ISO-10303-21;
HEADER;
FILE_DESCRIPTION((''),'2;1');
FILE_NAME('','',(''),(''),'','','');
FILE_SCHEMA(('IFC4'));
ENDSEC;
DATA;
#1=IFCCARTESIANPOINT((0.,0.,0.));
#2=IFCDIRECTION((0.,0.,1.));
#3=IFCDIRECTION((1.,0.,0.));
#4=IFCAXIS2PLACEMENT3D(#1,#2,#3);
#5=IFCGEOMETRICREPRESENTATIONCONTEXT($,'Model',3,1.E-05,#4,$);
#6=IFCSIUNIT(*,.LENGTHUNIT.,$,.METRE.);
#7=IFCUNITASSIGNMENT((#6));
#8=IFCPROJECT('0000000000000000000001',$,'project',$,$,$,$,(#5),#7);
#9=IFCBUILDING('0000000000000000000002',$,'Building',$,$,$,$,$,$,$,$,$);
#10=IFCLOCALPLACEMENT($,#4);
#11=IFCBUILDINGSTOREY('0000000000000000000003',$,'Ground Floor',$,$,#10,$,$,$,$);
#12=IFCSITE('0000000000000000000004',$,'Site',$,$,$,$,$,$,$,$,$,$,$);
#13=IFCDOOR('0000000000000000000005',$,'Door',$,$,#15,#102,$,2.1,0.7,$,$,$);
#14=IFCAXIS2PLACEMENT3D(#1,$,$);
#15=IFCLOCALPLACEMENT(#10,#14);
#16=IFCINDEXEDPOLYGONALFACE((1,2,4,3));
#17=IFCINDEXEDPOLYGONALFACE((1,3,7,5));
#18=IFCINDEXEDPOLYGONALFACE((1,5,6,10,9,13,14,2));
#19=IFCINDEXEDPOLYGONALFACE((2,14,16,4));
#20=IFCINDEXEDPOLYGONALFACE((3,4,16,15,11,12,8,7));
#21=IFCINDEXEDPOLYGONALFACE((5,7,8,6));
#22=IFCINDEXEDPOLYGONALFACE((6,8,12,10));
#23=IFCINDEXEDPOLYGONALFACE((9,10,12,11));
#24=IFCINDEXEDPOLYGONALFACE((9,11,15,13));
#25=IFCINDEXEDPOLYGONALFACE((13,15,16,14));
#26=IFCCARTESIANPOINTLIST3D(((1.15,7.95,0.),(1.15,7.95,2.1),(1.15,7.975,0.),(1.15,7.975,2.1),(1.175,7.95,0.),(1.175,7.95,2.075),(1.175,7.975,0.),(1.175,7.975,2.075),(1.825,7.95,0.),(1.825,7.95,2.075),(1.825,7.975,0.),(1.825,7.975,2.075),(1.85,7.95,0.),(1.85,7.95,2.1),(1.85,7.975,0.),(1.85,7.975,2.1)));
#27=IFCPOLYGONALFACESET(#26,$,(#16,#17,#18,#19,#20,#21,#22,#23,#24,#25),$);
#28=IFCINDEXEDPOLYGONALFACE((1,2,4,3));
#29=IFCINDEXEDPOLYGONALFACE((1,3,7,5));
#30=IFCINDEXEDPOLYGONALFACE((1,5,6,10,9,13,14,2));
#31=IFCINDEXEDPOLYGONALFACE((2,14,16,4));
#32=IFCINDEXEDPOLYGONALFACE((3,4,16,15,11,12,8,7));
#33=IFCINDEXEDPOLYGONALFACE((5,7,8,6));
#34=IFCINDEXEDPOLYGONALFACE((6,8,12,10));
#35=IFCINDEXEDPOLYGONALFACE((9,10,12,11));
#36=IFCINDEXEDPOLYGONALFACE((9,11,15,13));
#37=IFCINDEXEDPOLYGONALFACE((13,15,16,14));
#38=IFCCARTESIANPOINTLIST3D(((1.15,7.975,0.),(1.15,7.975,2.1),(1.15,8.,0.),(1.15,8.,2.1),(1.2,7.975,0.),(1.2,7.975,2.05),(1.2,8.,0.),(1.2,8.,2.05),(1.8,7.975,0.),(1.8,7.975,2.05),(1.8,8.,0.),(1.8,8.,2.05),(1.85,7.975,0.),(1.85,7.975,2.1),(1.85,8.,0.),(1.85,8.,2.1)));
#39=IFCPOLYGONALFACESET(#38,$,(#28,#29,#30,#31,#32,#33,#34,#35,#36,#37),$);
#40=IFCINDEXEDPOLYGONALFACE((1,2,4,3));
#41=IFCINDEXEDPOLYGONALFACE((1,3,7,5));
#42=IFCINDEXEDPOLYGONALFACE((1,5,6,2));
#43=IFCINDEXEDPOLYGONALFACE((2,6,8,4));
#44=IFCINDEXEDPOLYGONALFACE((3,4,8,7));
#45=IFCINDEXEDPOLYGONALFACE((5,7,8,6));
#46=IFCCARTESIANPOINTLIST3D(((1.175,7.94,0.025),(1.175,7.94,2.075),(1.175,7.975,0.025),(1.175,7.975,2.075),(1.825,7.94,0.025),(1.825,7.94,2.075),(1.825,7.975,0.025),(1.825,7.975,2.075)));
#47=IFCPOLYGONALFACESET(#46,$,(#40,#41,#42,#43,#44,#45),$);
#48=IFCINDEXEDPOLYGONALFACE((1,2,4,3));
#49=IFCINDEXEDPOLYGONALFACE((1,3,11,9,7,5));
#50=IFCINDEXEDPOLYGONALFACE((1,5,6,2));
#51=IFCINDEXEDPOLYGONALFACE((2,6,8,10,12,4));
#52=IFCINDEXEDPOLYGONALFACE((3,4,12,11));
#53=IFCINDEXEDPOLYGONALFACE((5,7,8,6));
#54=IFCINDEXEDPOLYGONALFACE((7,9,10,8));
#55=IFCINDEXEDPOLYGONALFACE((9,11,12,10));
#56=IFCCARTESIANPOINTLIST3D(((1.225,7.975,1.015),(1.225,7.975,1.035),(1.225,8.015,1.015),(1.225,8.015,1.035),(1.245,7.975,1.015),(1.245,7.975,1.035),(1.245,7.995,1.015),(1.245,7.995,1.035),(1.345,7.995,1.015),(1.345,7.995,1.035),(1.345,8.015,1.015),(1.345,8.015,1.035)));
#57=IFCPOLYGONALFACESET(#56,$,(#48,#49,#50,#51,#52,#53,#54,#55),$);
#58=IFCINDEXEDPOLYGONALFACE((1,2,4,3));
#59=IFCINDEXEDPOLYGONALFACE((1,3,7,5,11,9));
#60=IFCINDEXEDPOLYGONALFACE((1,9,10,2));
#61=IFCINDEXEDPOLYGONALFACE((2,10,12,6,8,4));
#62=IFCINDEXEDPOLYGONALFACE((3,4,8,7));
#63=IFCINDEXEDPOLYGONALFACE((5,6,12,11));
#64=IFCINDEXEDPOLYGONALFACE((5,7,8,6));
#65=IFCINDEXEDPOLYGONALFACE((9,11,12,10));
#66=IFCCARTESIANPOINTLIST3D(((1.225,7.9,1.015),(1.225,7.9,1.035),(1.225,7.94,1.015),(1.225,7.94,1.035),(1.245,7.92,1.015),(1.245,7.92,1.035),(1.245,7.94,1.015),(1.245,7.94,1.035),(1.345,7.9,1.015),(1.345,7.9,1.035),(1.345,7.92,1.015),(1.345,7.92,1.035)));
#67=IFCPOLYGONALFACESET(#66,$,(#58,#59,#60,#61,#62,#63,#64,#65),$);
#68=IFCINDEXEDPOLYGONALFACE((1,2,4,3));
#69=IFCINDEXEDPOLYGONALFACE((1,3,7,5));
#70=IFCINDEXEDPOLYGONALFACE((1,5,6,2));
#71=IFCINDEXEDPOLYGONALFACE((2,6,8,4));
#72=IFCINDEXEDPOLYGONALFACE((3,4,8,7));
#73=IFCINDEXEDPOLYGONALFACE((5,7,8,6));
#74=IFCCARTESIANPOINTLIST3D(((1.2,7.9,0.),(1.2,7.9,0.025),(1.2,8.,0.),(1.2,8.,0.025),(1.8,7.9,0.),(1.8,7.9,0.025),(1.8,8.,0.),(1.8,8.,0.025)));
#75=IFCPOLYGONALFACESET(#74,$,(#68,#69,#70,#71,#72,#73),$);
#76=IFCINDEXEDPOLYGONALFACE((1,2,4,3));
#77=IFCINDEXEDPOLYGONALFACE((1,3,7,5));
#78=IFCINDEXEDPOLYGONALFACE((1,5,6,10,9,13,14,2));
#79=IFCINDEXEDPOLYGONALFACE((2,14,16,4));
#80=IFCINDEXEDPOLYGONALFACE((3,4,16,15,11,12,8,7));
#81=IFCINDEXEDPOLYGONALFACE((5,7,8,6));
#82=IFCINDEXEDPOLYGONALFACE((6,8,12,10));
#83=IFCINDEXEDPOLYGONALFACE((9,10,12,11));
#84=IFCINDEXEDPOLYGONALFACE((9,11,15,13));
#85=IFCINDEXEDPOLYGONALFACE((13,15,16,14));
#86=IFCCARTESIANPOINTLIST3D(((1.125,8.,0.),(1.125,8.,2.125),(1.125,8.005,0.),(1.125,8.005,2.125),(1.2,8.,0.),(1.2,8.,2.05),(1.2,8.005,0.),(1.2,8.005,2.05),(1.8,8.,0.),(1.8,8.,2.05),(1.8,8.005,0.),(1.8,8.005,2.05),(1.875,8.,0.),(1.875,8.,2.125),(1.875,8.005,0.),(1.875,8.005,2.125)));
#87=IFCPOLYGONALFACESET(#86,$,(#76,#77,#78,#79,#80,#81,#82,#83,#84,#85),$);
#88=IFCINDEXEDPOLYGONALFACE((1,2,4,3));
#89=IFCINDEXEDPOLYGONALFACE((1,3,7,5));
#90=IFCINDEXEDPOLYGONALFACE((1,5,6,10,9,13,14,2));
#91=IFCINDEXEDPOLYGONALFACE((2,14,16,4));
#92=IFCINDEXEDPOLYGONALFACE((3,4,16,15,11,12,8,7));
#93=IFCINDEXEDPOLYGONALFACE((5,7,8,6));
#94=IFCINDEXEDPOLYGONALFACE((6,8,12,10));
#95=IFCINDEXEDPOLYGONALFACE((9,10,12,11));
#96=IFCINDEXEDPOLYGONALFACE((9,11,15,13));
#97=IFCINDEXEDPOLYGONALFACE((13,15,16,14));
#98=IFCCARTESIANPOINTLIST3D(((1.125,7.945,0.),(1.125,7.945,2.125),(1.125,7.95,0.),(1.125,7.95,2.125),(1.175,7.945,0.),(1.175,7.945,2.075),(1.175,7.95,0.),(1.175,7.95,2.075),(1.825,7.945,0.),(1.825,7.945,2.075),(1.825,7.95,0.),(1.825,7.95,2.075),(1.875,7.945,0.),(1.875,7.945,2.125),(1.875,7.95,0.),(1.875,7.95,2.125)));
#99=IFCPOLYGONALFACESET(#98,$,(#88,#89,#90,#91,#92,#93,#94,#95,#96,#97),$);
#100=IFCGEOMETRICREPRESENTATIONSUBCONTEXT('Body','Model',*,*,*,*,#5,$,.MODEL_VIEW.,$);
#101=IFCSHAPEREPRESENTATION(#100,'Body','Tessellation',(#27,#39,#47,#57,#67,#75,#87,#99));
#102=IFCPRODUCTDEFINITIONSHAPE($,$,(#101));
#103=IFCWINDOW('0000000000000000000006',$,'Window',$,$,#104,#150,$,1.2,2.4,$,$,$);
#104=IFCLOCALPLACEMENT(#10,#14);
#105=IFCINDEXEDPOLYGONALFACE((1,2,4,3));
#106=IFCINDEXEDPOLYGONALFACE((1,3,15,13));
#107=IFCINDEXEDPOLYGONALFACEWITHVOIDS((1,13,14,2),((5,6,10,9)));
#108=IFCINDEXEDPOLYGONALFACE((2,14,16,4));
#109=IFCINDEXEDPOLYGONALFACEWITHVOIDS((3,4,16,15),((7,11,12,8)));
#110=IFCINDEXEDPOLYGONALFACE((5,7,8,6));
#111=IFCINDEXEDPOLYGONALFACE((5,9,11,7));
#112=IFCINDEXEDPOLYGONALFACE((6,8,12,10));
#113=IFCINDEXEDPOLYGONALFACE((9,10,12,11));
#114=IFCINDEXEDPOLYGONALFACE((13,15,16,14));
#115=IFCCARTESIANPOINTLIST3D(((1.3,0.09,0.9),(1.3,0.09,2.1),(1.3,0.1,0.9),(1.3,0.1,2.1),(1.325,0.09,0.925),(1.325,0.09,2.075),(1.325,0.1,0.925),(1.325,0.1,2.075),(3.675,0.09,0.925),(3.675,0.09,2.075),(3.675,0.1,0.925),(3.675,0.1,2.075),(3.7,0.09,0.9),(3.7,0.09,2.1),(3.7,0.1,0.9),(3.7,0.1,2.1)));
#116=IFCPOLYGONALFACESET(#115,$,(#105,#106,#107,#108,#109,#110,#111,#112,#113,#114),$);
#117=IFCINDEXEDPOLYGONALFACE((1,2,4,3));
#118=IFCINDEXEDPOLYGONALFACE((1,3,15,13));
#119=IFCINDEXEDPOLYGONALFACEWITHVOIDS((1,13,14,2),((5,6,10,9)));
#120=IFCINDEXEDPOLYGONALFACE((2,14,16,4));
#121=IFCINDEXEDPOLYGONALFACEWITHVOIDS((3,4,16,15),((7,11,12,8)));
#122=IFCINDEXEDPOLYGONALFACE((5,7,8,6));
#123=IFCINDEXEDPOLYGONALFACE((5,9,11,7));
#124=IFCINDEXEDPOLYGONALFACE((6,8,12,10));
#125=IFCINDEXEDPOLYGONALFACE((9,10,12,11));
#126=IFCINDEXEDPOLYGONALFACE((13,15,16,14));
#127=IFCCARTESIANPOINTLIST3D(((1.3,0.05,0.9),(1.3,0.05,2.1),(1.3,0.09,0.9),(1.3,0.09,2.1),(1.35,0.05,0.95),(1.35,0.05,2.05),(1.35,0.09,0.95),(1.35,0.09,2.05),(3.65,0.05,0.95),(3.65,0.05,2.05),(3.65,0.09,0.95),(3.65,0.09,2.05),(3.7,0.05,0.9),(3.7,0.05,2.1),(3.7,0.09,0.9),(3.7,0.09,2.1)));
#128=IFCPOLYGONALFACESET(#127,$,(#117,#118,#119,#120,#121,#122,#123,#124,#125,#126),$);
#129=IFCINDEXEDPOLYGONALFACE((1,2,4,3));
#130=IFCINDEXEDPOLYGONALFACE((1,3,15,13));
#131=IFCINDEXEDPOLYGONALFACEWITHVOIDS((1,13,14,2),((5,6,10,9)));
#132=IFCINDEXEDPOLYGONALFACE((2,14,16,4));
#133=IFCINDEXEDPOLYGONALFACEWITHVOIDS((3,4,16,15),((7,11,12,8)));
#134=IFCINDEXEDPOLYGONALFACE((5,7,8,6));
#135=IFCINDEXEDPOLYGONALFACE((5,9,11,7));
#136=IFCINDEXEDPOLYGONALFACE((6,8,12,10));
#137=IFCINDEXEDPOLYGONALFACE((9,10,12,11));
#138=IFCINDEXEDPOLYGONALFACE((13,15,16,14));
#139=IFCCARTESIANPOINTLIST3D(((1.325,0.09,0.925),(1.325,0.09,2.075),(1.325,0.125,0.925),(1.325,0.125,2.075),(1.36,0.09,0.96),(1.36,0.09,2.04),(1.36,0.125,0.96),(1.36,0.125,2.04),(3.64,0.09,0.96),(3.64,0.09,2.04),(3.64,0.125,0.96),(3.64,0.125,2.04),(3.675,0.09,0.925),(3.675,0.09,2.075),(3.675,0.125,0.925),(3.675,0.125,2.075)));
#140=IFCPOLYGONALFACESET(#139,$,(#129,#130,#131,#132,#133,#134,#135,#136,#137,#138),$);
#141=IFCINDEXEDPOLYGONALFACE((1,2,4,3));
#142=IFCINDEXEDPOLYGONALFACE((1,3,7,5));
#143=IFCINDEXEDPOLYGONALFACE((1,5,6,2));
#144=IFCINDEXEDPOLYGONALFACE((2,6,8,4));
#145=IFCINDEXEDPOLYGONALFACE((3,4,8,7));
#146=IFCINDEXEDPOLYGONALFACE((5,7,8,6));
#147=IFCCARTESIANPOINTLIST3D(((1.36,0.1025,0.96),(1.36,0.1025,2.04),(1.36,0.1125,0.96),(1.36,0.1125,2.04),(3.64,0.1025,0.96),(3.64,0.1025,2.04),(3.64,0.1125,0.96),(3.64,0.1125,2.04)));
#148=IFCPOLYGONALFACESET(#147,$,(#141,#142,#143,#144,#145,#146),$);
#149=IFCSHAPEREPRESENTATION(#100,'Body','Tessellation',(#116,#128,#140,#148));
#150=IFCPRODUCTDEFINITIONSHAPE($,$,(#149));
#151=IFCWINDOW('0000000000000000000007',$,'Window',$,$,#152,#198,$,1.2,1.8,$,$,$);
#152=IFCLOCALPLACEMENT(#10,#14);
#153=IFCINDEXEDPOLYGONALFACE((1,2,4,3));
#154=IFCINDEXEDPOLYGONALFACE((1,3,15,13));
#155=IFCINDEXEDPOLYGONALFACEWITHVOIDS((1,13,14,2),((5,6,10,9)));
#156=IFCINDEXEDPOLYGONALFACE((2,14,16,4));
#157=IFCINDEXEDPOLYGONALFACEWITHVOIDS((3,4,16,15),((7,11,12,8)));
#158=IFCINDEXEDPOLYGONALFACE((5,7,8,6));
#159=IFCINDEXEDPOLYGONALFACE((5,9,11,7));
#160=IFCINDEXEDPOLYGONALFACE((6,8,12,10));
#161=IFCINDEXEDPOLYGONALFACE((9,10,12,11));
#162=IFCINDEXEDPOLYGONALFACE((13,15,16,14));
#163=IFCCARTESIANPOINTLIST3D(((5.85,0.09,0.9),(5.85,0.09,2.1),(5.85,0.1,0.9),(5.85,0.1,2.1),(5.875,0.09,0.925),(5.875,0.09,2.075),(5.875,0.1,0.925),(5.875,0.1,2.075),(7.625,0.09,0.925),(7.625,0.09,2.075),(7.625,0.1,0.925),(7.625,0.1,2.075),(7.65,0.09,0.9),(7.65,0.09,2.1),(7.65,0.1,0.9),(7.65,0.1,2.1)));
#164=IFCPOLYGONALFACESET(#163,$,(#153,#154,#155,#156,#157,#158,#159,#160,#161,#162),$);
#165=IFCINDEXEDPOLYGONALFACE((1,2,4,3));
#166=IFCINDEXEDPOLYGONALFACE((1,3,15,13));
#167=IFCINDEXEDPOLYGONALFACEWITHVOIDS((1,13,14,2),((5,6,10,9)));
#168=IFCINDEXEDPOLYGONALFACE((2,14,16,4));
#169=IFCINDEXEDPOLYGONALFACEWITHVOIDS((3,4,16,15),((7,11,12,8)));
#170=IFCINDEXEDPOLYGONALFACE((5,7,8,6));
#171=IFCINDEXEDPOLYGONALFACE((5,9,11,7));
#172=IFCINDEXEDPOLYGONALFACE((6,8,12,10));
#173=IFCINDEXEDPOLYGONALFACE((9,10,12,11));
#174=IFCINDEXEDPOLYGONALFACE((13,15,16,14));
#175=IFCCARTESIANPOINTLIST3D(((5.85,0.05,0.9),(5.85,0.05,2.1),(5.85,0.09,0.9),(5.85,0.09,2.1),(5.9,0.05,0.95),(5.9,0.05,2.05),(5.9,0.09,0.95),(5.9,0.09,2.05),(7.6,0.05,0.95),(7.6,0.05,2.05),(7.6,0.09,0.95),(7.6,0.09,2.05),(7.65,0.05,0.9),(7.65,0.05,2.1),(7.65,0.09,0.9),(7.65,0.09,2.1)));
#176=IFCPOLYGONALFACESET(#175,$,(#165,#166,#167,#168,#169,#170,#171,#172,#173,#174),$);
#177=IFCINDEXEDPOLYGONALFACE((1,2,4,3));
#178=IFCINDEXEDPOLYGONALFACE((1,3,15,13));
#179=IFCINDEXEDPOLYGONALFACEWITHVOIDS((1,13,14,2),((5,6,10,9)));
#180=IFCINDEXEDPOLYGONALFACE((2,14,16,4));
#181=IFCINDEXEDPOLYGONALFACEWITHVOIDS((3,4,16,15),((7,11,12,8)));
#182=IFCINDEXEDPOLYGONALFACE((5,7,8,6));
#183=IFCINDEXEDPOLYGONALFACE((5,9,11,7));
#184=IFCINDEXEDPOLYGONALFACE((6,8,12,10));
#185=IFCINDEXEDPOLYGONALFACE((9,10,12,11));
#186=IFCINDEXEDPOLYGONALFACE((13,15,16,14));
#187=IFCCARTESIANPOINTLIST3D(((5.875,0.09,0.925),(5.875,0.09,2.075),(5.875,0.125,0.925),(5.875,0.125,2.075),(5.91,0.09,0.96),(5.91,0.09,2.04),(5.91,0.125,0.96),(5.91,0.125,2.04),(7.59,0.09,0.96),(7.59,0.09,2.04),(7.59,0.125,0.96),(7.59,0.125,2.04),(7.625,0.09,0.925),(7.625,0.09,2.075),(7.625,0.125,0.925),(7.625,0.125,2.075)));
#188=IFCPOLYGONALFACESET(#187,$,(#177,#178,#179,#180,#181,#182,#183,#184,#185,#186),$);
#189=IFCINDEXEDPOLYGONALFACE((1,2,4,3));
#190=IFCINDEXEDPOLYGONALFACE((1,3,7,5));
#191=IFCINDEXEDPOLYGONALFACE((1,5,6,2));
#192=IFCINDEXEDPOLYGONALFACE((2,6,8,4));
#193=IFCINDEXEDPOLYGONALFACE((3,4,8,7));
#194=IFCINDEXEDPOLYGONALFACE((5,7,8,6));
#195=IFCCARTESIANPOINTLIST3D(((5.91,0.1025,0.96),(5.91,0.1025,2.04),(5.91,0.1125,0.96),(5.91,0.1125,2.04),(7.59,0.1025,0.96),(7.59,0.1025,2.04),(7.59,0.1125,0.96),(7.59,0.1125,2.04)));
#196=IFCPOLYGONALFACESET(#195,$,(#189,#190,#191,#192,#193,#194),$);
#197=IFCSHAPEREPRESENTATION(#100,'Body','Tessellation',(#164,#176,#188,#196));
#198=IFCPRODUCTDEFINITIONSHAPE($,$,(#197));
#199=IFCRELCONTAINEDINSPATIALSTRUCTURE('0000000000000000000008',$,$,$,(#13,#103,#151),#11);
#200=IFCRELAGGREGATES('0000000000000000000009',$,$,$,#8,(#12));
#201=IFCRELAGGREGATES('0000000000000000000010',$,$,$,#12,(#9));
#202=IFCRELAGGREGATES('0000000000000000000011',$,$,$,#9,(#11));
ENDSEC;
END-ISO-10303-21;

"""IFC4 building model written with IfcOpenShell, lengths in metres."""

from ifc_helpers import new_model, si_unit, frame, origin_with_axes, place, context, subcontext, project, spatial, line, indexed_curve, outline, extrude, element, save


model = new_model("IFC4")

# Units and contexts
model_context = context("Model", 3, precision=1e-05, world=origin_with_axes())
body_context = subcontext(model_context, "Body", "Model", "MODEL_VIEW")
ifc_project = project(units=[si_unit("LENGTHUNIT", "METRE")], contexts=[model_context])

# Site, building, storey
site = spatial("IfcSite", under=ifc_project, Name="Site")
building = spatial("IfcBuilding", under=site, Name="Building")
storey_placement = place(None, origin_with_axes())
storey = spatial("IfcBuildingStorey", under=building, at=storey_placement, Name="Ground Floor")

# Door
door_1_placement = place(storey_placement, frame((1.85, 8.0, 0.0), z_axis=(0.0, 0.0, 1.0), x_axis=(-1.0, 0.0, 0.0)))
element("IfcDoor", 1, at=door_1_placement, inside=storey, Name="Door", OverallHeight=2.1, OverallWidth=0.7, context=body_context, shape_type="SweptSolid", body=[
    extrude(outline(indexed_curve([(0.0, 0.0), (0.0, 2.1), (0.7, 2.1), (0.7, 0.0), (0.675, 0.0), (0.675, 2.075), (0.025, 2.075), (0.025, 0.0)], segments=[line(1, 2, 3, 4, 5, 6, 7, 8, 1)])), frame((0.0, 0.025, 0.0), z_axis=(0.0, -1.0, 0.0), x_axis=(1.0, 0.0, 0.0)), (0.0, 0.0, -1.0), 0.025),
    extrude(outline(indexed_curve([(0.0, 0.0), (0.0, 2.1), (0.7, 2.1), (0.7, 0.0), (0.65, 0.0), (0.65, 2.05), (0.05, 2.05), (0.05, 0.0)], segments=[line(1, 2, 3, 4, 5, 6, 7, 8, 1)])), frame((0.0, 0.0, 0.0), z_axis=(0.0, -1.0, 0.0), x_axis=(1.0, 0.0, 0.0)), (0.0, 0.0, -1.0), 0.025),
    extrude(outline(indexed_curve([(0.0, 0.0), (0.65, 0.0), (0.65, 0.035), (0.0, 0.035)], segments=[line(1, 2, 3, 4, 1)])), frame((0.025, 0.025, 0.025), z_axis=(0.0, 0.0, 1.0), x_axis=(1.0, 0.0, 0.0)), (0.0, 0.0, 1.0), 2.05),
    extrude(outline(indexed_curve([(0.0, 0.0), (0.0, -0.04), (-0.12, -0.04), (-0.12, -0.02), (-0.02, -0.02), (-0.02, 0.0)], segments=[line(1, 2, 3, 4, 5, 6, 1)])), frame((0.625, 0.025, 1.015), z_axis=(0.0, 0.0, 1.0), x_axis=(1.0, 0.0, 0.0)), (0.0, 0.0, 1.0), 0.02),
    extrude(outline(indexed_curve([(0.0, 0.0), (0.0, 0.04), (-0.12, 0.04), (-0.12, 0.02), (-0.02, 0.02), (-0.02, 0.0)], segments=[line(1, 2, 3, 4, 5, 6, 1)])), frame((0.625, 0.06, 1.015), z_axis=(0.0, 0.0, 1.0), x_axis=(1.0, 0.0, 0.0)), (0.0, 0.0, 1.0), 0.02),
    extrude(outline(indexed_curve([(0.0, 0.0), (0.6, 0.0), (0.6, 0.1), (0.0, 0.1)], segments=[line(1, 2, 3, 4, 1)])), frame((0.05, 0.0, 0.0), z_axis=(0.0, 0.0, 1.0), x_axis=(1.0, 0.0, 0.0)), (0.0, 0.0, 1.0), 0.025),
    extrude(outline(indexed_curve([(0.0, 0.0), (0.0, 2.125), (0.75, 2.125), (0.75, 0.0), (0.675, 0.0), (0.675, 2.05), (0.075, 2.05), (0.075, 0.0)], segments=[line(1, 2, 3, 4, 5, 6, 7, 8, 1)])), frame((-0.025, -0.005, 0.0), z_axis=(0.0, -1.0, 0.0), x_axis=(1.0, 0.0, 0.0)), (0.0, 0.0, -1.0), 0.005),
    extrude(outline(indexed_curve([(0.0, 0.0), (0.0, 2.125), (0.75, 2.125), (0.75, 0.0), (0.7, 0.0), (0.7, 2.075), (0.05, 2.075), (0.05, 0.0)], segments=[line(1, 2, 3, 4, 5, 6, 7, 8, 1)])), frame((-0.025, 0.05, 0.0), z_axis=(0.0, -1.0, 0.0), x_axis=(1.0, 0.0, 0.0)), (0.0, 0.0, -1.0), 0.005),
])

# Windows
window_1_placement = place(storey_placement, frame((1.3, 0.0, 0.9), z_axis=(0.0, 0.0, 1.0), x_axis=(1.0, 0.0, 0.0)))
element("IfcWindow", 2, at=window_1_placement, inside=storey, Name="Window", OverallHeight=1.2, OverallWidth=2.4, context=body_context, shape_type="SweptSolid", body=[
    extrude(outline(indexed_curve([(0.0, 0.0), (2.4, 0.0), (2.4, 1.2), (0.0, 1.2)], segments=[line(1, 2, 3, 4, 1)]), holes=[indexed_curve([(0.025, 0.025), (2.375, 0.025), (2.375, 1.175), (0.025, 1.175)], segments=[line(1, 2, 3, 4, 1)])]), frame((0.0, 0.09, 0.0), z_axis=(0.0, -1.0, 0.0), x_axis=(1.0, 0.0, 0.0)), (0.0, 0.0, -1.0), 0.01),
    extrude(outline(indexed_curve([(0.0, 0.0), (2.4, 0.0), (2.4, 1.2), (0.0, 1.2)], segments=[line(1, 2, 3, 4, 1)]), holes=[indexed_curve([(0.05, 0.05), (2.35, 0.05), (2.35, 1.15), (0.05, 1.15)], segments=[line(1, 2, 3, 4, 1)])]), frame((0.0, 0.05, 0.0), z_axis=(0.0, -1.0, 0.0), x_axis=(1.0, 0.0, 0.0)), (0.0, 0.0, -1.0), 0.04),
    extrude(outline(indexed_curve([(0.0, 0.0), (2.35, 0.0), (2.35, 1.15), (0.0, 1.15)], segments=[line(1, 2, 3, 4, 1)]), holes=[indexed_curve([(0.035, 0.035), (2.315, 0.035), (2.315, 1.115), (0.035, 1.115)], segments=[line(1, 2, 3, 4, 1)])]), frame((0.025, 0.09, 0.025), z_axis=(0.0, -1.0, 0.0), x_axis=(1.0, 0.0, 0.0)), (0.0, 0.0, -1.0), 0.035),
    extrude(outline(indexed_curve([(0.035, 0.035), (2.315, 0.035), (2.315, 1.115), (0.035, 1.115)], segments=[line(1, 2, 3, 4, 1)])), frame((0.025, 0.1025, 0.025), z_axis=(0.0, -1.0, 0.0), x_axis=(1.0, 0.0, 0.0)), (0.0, 0.0, -1.0), 0.01),
])
window_2_placement = place(storey_placement, frame((5.85, 0.0, 0.9), z_axis=(0.0, 0.0, 1.0), x_axis=(1.0, 0.0, 0.0)))
element("IfcWindow", 3, at=window_2_placement, inside=storey, Name="Window", OverallHeight=1.2, OverallWidth=1.8, context=body_context, shape_type="SweptSolid", body=[
    extrude(outline(indexed_curve([(0.0, 0.0), (1.8, 0.0), (1.8, 1.2), (0.0, 1.2)], segments=[line(1, 2, 3, 4, 1)]), holes=[indexed_curve([(0.025, 0.025), (1.775, 0.025), (1.775, 1.175), (0.025, 1.175)], segments=[line(1, 2, 3, 4, 1)])]), frame((0.0, 0.09, 0.0), z_axis=(0.0, -1.0, 0.0), x_axis=(1.0, 0.0, 0.0)), (0.0, 0.0, -1.0), 0.01),
    extrude(outline(indexed_curve([(0.0, 0.0), (1.8, 0.0), (1.8, 1.2), (0.0, 1.2)], segments=[line(1, 2, 3, 4, 1)]), holes=[indexed_curve([(0.05, 0.05), (1.75, 0.05), (1.75, 1.15), (0.05, 1.15)], segments=[line(1, 2, 3, 4, 1)])]), frame((0.0, 0.05, 0.0), z_axis=(0.0, -1.0, 0.0), x_axis=(1.0, 0.0, 0.0)), (0.0, 0.0, -1.0), 0.04),
    extrude(outline(indexed_curve([(0.0, 0.0), (1.75, 0.0), (1.75, 1.15), (0.0, 1.15)], segments=[line(1, 2, 3, 4, 1)]), holes=[indexed_curve([(0.035, 0.035), (1.715, 0.035), (1.715, 1.115), (0.035, 1.115)], segments=[line(1, 2, 3, 4, 1)])]), frame((0.025, 0.09, 0.025), z_axis=(0.0, -1.0, 0.0), x_axis=(1.0, 0.0, 0.0)), (0.0, 0.0, -1.0), 0.035),
    extrude(outline(indexed_curve([(0.035, 0.035), (1.715, 0.035), (1.715, 1.115), (0.035, 1.115)], segments=[line(1, 2, 3, 4, 1)])), frame((0.025, 0.1025, 0.025), z_axis=(0.0, -1.0, 0.0), x_axis=(1.0, 0.0, 0.0)), (0.0, 0.0, -1.0), 0.01),
])

save(model, "model.ifc")
